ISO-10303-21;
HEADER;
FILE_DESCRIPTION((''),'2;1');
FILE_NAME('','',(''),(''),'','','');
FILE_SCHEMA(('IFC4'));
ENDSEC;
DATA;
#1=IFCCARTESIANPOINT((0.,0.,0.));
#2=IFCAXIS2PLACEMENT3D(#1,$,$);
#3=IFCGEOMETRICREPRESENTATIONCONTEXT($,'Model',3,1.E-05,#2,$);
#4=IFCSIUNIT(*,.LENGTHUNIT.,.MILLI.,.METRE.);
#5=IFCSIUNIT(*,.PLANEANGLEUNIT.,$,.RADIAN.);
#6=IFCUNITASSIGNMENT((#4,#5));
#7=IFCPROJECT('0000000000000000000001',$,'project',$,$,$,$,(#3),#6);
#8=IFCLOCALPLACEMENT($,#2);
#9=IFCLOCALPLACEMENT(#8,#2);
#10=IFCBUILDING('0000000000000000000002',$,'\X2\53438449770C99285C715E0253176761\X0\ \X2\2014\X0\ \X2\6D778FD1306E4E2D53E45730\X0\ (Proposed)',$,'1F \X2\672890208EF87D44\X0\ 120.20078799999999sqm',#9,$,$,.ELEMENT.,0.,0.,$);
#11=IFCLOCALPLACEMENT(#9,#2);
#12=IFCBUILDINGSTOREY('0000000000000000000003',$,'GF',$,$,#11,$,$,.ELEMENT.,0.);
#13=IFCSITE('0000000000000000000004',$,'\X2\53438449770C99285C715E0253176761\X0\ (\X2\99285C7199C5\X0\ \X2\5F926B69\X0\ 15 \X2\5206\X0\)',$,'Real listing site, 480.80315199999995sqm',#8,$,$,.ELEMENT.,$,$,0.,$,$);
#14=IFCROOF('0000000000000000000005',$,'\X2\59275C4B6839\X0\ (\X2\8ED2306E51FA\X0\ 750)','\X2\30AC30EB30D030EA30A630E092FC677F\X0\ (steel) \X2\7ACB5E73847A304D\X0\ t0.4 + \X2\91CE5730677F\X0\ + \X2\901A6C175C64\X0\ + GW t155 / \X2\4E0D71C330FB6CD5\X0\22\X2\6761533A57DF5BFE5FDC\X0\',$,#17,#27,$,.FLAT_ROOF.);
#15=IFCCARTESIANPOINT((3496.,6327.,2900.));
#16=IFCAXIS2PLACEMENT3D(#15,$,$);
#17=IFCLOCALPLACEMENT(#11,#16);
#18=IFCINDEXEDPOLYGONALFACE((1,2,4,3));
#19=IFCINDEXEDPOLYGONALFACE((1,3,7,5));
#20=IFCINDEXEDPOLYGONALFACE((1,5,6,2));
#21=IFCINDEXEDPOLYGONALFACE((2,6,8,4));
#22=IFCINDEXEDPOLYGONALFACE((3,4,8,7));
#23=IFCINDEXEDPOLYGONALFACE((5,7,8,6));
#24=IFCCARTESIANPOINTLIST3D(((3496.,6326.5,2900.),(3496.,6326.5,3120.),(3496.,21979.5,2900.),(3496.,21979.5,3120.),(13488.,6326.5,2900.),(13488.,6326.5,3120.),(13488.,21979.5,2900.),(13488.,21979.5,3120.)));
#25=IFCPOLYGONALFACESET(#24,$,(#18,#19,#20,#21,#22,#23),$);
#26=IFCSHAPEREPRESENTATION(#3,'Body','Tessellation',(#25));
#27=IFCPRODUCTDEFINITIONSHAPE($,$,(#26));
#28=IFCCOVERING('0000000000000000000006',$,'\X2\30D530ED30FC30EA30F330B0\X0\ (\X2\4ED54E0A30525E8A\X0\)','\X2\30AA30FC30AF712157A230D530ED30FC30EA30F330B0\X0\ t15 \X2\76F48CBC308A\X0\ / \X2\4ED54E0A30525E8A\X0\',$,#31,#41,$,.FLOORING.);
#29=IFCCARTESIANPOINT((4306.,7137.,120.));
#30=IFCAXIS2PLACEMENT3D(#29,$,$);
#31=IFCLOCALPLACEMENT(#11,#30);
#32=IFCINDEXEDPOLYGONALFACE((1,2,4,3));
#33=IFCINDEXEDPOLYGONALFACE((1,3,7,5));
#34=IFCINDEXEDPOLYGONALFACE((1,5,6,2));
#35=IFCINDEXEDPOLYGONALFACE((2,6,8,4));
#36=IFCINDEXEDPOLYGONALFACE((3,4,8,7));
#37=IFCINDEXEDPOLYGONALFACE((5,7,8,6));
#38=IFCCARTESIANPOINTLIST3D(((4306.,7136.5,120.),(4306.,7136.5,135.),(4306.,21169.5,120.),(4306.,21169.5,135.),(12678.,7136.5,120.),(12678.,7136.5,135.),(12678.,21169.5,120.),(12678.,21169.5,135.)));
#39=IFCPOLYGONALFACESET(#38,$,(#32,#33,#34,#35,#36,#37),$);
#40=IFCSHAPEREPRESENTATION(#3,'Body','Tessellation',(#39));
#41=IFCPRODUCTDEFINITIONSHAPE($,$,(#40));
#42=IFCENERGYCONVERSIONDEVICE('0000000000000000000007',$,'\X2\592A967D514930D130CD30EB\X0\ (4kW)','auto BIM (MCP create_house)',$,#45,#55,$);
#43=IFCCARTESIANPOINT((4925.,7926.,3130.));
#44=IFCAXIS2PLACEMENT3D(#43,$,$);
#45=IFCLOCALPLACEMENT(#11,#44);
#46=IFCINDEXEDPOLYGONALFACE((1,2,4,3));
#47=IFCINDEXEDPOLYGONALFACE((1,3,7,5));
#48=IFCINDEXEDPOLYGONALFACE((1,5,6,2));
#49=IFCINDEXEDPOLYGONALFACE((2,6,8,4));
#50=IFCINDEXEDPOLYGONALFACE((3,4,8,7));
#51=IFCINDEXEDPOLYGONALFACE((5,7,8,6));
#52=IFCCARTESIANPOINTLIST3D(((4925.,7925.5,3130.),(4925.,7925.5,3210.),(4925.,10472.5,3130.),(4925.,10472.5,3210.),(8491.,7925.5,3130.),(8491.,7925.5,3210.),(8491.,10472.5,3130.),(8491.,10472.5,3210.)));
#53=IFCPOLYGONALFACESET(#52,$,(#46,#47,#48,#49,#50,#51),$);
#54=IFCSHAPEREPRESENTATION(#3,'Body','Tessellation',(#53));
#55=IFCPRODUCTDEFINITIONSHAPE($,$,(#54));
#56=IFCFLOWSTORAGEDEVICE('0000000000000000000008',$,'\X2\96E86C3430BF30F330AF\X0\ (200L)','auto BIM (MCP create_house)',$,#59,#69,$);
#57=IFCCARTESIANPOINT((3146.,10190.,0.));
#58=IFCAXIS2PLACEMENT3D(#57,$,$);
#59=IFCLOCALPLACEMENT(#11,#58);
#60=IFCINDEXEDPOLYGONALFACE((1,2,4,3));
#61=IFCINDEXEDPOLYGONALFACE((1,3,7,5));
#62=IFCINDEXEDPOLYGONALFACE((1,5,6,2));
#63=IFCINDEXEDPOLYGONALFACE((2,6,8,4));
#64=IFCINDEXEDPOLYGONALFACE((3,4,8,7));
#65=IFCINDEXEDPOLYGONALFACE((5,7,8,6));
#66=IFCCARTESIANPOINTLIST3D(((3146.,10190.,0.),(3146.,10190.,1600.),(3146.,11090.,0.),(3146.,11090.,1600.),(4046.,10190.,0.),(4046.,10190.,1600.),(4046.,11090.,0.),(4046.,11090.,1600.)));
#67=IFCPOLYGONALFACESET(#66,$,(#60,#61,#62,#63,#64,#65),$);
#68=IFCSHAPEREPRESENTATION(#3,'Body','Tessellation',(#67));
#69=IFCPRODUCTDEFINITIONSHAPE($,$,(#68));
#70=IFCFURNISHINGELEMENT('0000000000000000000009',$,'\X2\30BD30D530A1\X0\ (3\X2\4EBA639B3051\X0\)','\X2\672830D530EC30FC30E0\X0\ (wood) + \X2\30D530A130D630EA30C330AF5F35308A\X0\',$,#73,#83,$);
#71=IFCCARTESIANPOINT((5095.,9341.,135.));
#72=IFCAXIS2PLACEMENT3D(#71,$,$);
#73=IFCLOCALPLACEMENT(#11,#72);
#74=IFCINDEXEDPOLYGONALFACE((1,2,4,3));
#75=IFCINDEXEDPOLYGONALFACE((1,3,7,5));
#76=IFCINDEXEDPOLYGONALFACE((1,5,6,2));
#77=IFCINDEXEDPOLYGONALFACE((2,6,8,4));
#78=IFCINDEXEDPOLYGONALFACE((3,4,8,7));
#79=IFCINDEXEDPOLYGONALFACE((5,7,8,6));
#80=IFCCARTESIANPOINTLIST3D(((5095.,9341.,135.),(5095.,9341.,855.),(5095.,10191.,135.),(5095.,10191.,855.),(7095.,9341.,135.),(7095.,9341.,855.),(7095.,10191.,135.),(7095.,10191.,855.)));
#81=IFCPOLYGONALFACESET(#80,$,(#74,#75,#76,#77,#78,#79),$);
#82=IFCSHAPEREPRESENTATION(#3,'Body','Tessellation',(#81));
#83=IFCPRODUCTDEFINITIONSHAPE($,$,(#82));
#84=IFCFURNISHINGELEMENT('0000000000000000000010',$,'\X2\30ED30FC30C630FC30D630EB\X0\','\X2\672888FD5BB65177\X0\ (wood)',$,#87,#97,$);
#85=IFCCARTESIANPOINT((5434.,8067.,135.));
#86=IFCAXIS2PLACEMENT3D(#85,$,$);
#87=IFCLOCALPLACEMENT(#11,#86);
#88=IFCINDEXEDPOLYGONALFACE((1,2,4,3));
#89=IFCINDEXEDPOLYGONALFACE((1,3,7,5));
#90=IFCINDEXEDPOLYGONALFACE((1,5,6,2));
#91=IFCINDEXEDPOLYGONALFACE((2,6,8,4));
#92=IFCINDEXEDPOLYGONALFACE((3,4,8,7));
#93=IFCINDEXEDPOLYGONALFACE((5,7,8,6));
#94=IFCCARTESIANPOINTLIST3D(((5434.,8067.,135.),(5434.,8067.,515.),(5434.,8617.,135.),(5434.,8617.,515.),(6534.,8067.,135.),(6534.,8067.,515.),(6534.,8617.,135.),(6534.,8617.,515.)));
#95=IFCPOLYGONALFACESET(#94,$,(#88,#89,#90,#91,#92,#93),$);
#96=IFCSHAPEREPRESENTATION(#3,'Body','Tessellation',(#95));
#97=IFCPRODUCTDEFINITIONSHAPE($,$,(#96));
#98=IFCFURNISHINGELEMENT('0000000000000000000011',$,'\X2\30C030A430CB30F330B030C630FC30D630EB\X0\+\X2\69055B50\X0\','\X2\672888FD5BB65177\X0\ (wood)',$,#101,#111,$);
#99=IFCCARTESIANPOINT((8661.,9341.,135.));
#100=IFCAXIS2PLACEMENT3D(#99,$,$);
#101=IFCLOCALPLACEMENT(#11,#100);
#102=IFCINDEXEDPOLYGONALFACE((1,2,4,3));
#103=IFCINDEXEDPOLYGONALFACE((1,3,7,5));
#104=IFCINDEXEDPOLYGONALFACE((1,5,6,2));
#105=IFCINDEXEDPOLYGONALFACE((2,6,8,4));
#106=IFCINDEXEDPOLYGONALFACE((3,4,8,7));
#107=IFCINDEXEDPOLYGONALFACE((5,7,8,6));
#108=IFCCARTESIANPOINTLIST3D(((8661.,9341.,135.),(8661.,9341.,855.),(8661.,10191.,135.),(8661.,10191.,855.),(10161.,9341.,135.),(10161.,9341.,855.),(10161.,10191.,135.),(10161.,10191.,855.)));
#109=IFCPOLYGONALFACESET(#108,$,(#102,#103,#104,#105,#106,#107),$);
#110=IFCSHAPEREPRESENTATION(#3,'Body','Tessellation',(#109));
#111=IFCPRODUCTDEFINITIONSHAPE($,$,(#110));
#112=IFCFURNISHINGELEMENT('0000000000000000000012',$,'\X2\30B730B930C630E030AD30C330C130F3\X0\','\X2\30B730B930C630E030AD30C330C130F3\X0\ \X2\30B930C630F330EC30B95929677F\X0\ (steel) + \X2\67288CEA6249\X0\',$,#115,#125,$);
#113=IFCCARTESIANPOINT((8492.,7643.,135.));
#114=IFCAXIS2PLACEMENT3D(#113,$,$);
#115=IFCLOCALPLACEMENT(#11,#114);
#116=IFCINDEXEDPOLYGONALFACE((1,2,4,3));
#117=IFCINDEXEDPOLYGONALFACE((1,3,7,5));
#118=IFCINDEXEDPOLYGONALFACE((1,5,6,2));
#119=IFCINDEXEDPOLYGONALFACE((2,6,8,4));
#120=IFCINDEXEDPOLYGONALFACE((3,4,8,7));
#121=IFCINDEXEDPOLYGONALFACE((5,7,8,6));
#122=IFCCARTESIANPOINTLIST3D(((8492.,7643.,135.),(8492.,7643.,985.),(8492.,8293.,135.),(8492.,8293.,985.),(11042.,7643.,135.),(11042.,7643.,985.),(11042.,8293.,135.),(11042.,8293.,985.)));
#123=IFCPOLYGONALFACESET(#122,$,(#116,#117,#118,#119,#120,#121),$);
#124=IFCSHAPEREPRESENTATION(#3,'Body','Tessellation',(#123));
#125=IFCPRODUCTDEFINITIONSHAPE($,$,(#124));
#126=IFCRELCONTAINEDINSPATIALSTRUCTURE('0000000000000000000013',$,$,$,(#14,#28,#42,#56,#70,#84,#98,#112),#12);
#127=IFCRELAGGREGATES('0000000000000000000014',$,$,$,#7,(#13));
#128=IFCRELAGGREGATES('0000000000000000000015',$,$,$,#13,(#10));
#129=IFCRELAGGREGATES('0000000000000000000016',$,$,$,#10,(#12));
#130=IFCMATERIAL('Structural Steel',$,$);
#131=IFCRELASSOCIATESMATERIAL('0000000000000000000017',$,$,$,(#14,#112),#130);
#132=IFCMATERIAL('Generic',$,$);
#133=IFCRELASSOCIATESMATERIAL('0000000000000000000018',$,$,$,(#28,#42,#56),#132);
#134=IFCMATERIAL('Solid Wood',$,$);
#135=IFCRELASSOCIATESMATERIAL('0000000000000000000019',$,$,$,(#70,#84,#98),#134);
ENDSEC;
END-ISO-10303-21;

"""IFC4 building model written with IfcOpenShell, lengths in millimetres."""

from ifc_helpers import new_model, si_unit, frame, frame_2d, origin, place, context, project, spatial, rectangle, extrude, material, element, save


model = new_model("IFC4")

# Units and contexts
model_context = context("Model", 3, precision=1e-05, world=origin())
ifc_project = project(units=[si_unit("LENGTHUNIT", "METRE", prefix="MILLI"), si_unit("PLANEANGLEUNIT", "RADIAN")], contexts=[model_context])

# Site, building, storey
site_placement = place(None, origin())
site = spatial("IfcSite", under=ifc_project, at=site_placement, Name="千葉県館山市北条 (館山駅 徒歩 15 分)", ObjectType="Real listing site, 480.80315199999995sqm", CompositionType="ELEMENT", RefElevation=0.0)
building_placement = place(site_placement, origin())
building = spatial("IfcBuilding", under=site, at=building_placement, Name="千葉県館山市北条 — 海近の中古地 (Proposed)", ObjectType="1F 木造軸組 120.20078799999999sqm", CompositionType="ELEMENT", ElevationOfRefHeight=0.0, ElevationOfTerrain=0.0)
storey_placement = place(building_placement, origin())
storey = spatial("IfcBuildingStorey", under=building, at=storey_placement, Name="GF", CompositionType="ELEMENT", Elevation=0.0)

# Shared definitions
ifc_material_1 = material(Name="Solid Wood")

# Roof
ifc_material_2 = material(Name="Structural Steel")
roof_placement = place(storey_placement, frame((3496.0, 6327.0, 2900.0)))
element("IfcRoof", 1, at=roof_placement, inside=storey, material=ifc_material_2, Name="大屋根 (軒の出 750)", Description="ガルバリウム鋼板 (steel) 立平葺き t0.4 + 野地板 + 通気層 + GW t155 / 不燃・法22条区域対応", PredefinedType="FLAT_ROOF", context=model_context, shape_type="SweptSolid", body=[
    extrude(rectangle(XDim=9992.0, YDim=15653.0, at=frame_2d((4996.0, 7826.0))), frame((3496.0, 6327.0, 2900.0)), (0.0, 0.0, 1.0), 220.0),
])

# Covering
ifc_material_3 = material(Name="Generic")
covering_placement = place(storey_placement, frame((4306.0, 7137.0, 120.0)))
element("IfcCovering", 2, at=covering_placement, inside=storey, material=ifc_material_3, Name="フローリング (仕上げ床)", Description="オーク無垢フローリング t15 直貼り / 仕上げ床", PredefinedType="FLOORING", context=model_context, shape_type="SweptSolid", body=[
    extrude(rectangle(XDim=8372.0, YDim=14033.0, at=frame_2d((4186.0, 7016.0))), frame((4306.0, 7137.0, 120.0)), (0.0, 0.0, 1.0), 15.0),
])

# Energy conversion device
energy_conversion_device_placement = place(storey_placement, frame((4925.0, 7926.0, 3130.0)))
element("IfcEnergyConversionDevice", 3, at=energy_conversion_device_placement, inside=storey, material=ifc_material_3, Name="太陽光パネル (4kW)", Description="auto BIM (MCP create_house)", context=model_context, shape_type="SweptSolid", body=[
    extrude(rectangle(XDim=3566.0, YDim=2547.0, at=frame_2d((1783.0, 1273.0))), frame((4925.0, 7926.0, 3130.0)), (0.0, 0.0, 1.0), 80.0),
])

# Flow storage device
flow_storage_device_placement = place(storey_placement, frame((3146.0, 10190.0, 0.0)))
element("IfcFlowStorageDevice", 4, at=flow_storage_device_placement, inside=storey, material=ifc_material_3, Name="雨水タンク (200L)", Description="auto BIM (MCP create_house)", context=model_context, shape_type="SweptSolid", body=[
    extrude(rectangle(XDim=900.0, YDim=900.0, at=frame_2d((450.0, 450.0))), frame((3146.0, 10190.0, 0.0)), (0.0, 0.0, 1.0), 1600.0),
])

# Furnishing elements
furnishing_1_placement = place(storey_placement, frame((5095.0, 9341.0, 135.0)))
element("IfcFurnishingElement", 5, at=furnishing_1_placement, inside=storey, material=ifc_material_1, Name="ソファ (3人掛け)", Description="木フレーム (wood) + ファブリック張り", context=model_context, shape_type="SweptSolid", body=[
    extrude(rectangle(XDim=2000.0, YDim=850.0, at=frame_2d((1000.0, 425.0))), frame((5095.0, 9341.0, 135.0)), (0.0, 0.0, 1.0), 720.0),
])
furnishing_2_placement = place(storey_placement, frame((5434.0, 8067.0, 135.0)))
element("IfcFurnishingElement", 6, at=furnishing_2_placement, inside=storey, material=ifc_material_1, Name="ローテーブル", Description="木製家具 (wood)", context=model_context, shape_type="SweptSolid", body=[
    extrude(rectangle(XDim=1100.0, YDim=550.0, at=frame_2d((550.0, 275.0))), frame((5434.0, 8067.0, 135.0)), (0.0, 0.0, 1.0), 380.0),
])
furnishing_3_placement = place(storey_placement, frame((8661.0, 9341.0, 135.0)))
element("IfcFurnishingElement", 7, at=furnishing_3_placement, inside=storey, material=ifc_material_1, Name="ダイニングテーブル+椅子", Description="木製家具 (wood)", context=model_context, shape_type="SweptSolid", body=[
    extrude(rectangle(XDim=1500.0, YDim=850.0, at=frame_2d((750.0, 425.0))), frame((8661.0, 9341.0, 135.0)), (0.0, 0.0, 1.0), 720.0),
])
furnishing_4_placement = place(storey_placement, frame((8492.0, 7643.0, 135.0)))
element("IfcFurnishingElement", 8, at=furnishing_4_placement, inside=storey, material=ifc_material_2, Name="システムキッチン", Description="システムキッチン ステンレス天板 (steel) + 木質扉", context=model_context, shape_type="SweptSolid", body=[
    extrude(rectangle(XDim=2550.0, YDim=650.0, at=frame_2d((1275.0, 325.0))), frame((8492.0, 7643.0, 135.0)), (0.0, 0.0, 1.0), 850.0),
])

save(model, "model.ifc")
